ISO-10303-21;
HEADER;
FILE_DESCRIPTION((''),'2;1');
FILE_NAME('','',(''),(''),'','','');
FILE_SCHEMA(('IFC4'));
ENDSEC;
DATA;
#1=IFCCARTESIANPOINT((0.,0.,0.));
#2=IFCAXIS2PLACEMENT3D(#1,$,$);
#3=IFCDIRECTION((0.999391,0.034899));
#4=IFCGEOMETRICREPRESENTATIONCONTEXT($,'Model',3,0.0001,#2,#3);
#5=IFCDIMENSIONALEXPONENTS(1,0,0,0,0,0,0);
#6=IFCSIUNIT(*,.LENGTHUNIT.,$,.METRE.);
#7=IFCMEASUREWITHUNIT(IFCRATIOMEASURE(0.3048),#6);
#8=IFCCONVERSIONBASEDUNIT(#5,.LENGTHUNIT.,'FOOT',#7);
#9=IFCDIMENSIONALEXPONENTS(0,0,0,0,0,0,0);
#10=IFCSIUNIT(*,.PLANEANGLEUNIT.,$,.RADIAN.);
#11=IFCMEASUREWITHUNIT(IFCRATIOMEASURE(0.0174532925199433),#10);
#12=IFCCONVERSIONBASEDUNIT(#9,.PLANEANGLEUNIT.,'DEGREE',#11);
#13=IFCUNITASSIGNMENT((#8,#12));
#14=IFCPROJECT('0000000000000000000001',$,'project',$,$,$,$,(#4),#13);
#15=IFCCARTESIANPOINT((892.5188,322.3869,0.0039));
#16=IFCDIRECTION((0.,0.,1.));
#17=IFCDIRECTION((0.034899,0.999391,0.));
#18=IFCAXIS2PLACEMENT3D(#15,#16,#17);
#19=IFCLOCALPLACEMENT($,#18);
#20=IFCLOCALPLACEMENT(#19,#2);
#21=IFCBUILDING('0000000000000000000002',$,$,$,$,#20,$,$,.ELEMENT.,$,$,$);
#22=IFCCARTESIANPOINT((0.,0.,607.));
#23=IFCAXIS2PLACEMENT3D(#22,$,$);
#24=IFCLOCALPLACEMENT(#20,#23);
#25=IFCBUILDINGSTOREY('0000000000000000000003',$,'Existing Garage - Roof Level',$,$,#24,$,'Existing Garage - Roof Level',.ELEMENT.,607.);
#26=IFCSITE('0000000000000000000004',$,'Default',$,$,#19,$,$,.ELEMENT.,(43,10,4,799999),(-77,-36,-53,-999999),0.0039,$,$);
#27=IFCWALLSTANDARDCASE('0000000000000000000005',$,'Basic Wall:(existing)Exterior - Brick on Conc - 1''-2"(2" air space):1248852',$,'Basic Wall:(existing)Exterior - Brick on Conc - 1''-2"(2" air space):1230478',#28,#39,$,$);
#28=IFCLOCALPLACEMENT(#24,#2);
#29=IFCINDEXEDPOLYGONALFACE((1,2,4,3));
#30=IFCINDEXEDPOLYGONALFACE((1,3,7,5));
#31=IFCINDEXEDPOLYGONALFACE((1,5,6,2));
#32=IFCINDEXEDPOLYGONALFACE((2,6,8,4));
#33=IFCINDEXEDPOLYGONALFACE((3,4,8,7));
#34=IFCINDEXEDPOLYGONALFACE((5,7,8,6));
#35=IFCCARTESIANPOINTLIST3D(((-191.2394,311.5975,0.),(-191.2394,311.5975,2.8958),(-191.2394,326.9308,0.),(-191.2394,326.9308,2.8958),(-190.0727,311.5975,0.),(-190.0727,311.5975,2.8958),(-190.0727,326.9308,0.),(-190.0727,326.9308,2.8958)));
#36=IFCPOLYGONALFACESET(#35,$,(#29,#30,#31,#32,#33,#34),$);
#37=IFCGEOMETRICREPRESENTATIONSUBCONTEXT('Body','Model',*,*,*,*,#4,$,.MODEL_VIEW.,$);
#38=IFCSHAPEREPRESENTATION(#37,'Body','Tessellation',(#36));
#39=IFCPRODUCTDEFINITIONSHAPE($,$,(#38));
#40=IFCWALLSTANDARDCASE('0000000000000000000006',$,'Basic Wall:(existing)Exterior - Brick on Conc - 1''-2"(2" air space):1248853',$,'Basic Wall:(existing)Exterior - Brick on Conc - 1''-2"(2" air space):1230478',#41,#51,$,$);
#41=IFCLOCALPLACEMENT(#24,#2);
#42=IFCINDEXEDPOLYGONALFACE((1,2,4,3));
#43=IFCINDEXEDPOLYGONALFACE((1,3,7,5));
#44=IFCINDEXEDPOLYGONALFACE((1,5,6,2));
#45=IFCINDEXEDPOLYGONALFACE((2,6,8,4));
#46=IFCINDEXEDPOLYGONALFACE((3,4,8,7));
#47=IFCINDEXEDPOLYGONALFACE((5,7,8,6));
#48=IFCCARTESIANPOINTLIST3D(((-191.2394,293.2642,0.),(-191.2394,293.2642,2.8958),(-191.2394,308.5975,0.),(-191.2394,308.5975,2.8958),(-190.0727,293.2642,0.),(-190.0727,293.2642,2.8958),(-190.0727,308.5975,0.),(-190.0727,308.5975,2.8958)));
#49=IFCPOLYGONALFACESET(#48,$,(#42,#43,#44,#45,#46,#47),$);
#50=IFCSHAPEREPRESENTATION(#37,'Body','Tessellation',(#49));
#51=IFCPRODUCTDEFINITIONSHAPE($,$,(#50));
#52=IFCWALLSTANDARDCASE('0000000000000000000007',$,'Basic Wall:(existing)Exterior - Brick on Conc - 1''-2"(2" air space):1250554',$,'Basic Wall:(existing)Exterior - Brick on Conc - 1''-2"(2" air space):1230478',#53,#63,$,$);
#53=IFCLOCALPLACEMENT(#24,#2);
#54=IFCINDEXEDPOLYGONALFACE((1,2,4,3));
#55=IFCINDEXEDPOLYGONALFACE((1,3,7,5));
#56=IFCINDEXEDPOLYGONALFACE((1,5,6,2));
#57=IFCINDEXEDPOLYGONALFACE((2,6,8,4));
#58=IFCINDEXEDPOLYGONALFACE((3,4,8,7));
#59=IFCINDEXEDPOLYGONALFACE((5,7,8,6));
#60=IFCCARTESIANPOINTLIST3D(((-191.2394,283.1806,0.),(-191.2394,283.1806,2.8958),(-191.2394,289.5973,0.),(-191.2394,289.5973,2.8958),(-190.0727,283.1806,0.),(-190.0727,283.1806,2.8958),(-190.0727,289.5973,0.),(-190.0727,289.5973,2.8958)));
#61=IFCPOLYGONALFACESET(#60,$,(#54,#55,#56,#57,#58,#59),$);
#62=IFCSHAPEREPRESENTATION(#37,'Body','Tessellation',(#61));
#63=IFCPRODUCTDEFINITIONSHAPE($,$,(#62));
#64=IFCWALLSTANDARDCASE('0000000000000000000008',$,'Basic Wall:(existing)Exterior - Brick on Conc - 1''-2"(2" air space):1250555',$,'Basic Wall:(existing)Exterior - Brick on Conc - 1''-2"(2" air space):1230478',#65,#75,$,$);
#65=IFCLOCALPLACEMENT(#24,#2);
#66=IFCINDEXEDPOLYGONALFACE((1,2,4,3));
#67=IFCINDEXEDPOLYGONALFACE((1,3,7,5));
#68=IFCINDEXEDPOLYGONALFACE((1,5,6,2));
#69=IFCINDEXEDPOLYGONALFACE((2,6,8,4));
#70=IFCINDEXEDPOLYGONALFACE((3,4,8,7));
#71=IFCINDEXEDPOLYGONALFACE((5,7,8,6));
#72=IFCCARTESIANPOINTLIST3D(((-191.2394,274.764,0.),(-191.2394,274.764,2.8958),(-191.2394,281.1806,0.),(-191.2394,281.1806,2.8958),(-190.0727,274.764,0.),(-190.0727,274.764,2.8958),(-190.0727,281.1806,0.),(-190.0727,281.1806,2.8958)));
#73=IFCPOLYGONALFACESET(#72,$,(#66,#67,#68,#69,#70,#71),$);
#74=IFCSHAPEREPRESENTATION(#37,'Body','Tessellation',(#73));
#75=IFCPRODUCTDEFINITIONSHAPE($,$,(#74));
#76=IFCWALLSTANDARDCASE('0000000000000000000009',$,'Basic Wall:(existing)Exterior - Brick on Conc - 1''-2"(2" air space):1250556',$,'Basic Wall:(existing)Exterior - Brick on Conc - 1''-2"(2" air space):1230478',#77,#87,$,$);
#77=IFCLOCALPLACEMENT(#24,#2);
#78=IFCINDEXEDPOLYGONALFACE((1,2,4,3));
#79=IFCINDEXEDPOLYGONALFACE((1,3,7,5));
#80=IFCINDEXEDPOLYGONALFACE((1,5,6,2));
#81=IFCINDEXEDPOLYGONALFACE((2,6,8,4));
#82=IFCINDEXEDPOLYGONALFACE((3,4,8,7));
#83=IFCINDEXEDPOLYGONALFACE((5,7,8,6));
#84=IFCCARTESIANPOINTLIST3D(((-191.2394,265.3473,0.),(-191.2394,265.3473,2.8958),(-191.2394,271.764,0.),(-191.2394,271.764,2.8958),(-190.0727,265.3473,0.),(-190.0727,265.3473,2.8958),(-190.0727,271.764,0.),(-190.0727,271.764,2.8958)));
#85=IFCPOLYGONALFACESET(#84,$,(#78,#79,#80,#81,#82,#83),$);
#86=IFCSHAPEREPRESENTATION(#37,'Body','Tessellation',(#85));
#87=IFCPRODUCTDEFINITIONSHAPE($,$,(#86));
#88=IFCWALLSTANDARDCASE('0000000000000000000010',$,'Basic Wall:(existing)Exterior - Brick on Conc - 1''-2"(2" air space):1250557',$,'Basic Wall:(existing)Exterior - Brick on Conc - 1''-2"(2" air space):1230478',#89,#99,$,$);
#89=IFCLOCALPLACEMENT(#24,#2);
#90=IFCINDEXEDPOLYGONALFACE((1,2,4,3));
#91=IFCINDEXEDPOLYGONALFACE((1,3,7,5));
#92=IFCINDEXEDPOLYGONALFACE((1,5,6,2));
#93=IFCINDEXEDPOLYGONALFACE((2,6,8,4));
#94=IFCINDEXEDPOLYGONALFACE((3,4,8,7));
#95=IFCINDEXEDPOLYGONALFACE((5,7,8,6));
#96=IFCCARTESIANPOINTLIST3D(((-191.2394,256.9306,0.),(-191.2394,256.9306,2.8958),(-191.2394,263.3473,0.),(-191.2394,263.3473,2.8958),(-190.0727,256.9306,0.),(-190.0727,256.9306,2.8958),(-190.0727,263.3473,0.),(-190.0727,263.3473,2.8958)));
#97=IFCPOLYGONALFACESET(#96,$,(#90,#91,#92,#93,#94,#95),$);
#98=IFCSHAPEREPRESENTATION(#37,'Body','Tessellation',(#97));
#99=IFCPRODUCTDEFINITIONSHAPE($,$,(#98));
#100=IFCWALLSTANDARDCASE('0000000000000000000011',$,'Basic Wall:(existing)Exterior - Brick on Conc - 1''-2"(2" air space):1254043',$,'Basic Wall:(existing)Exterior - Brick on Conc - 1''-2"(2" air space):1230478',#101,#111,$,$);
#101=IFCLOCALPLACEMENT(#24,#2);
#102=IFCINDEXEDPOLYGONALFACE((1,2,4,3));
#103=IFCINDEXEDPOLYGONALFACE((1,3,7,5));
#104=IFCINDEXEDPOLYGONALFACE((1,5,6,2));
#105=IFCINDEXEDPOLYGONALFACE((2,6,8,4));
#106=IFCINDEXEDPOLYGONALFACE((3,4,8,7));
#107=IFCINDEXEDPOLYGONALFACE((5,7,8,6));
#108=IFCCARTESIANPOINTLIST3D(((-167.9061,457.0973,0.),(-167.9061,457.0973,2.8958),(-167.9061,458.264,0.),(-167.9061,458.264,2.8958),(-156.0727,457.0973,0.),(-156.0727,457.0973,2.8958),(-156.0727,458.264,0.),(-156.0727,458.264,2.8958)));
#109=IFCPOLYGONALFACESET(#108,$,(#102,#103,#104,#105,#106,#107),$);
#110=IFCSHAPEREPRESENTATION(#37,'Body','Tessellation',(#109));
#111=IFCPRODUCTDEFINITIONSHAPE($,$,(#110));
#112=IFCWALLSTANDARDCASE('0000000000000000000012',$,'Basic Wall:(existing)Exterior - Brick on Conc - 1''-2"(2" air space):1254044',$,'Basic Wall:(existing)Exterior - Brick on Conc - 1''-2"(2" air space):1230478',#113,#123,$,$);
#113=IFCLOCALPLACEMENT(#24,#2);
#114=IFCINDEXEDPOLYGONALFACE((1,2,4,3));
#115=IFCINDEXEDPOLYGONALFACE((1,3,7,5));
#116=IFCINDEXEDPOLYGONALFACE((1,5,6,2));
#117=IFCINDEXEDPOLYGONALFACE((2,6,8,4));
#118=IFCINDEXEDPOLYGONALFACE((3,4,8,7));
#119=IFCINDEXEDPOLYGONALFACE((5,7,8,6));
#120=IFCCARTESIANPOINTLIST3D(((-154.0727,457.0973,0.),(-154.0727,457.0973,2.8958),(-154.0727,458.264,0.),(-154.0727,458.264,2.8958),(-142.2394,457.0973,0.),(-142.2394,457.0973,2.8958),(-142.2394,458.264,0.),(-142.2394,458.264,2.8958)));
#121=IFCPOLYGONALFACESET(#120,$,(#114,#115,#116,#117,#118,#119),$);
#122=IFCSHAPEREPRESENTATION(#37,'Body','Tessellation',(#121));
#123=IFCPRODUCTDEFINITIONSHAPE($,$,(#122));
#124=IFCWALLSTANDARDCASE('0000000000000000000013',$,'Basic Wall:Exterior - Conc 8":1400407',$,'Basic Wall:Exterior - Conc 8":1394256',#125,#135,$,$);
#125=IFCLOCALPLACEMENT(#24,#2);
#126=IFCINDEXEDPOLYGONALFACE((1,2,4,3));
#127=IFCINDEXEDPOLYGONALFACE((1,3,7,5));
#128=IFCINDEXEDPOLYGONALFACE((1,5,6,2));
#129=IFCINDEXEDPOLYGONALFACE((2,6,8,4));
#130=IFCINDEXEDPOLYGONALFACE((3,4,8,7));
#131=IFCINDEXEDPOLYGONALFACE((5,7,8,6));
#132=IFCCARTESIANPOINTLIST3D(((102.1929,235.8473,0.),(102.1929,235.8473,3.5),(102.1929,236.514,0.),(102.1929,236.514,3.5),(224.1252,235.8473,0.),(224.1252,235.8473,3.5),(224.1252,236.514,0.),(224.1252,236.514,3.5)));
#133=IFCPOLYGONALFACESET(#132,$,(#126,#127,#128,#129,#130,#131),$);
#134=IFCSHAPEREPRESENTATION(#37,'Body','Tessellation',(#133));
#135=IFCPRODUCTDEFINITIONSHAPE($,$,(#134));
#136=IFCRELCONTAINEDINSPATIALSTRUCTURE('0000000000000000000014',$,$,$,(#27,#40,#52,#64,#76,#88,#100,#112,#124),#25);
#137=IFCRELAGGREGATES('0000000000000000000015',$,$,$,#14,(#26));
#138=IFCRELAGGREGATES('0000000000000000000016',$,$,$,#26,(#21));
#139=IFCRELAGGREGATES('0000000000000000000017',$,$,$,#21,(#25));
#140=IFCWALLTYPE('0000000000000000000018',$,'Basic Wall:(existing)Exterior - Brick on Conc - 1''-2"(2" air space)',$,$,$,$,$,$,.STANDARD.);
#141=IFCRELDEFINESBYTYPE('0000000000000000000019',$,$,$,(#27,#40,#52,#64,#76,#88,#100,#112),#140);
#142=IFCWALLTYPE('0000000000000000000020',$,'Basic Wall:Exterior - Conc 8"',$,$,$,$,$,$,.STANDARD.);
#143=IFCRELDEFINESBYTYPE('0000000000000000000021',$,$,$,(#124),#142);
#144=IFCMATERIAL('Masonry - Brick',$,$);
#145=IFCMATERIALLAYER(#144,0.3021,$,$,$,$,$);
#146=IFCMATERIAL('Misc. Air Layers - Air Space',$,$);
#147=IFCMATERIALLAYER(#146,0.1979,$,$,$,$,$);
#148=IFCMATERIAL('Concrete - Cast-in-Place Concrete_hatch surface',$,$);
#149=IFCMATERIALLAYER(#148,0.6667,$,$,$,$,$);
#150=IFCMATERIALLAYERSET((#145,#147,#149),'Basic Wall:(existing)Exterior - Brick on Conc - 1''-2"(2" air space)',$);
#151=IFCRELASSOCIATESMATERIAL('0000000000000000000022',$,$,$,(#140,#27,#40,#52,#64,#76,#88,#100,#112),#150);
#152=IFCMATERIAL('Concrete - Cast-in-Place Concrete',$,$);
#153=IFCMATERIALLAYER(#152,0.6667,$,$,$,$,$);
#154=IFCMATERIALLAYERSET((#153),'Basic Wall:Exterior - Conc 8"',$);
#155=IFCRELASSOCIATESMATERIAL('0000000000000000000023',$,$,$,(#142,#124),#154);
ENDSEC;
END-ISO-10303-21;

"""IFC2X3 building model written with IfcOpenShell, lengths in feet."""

from ifc_helpers import new_model, entity, si_unit, converted_unit, direction, frame, frame_2d, origin, place, context, subcontext, project, spatial, rectangle, extrude, material, layer, layer_set, layer_usage, type_object, element, save


model = new_model("IFC2X3")

# Units and contexts
model_context = context("Model", 3, precision=0.0001, world=origin(), true_north=direction((0.999391, 0.034899)))
body_context = subcontext(model_context, "Body", "Model", "MODEL_VIEW")
ifc_project = project(units=[converted_unit("LENGTHUNIT", "FOOT", entity("IfcRatioMeasure", 0.3048), si_unit("LENGTHUNIT", "METRE"), dimensions=[1, 0, 0, 0, 0, 0, 0]), converted_unit("PLANEANGLEUNIT", "DEGREE", entity("IfcRatioMeasure", 0.0174532925199433), si_unit("PLANEANGLEUNIT", "RADIAN"), dimensions=[0, 0, 0, 0, 0, 0, 0])], contexts=[model_context])

# Site, building, storey
site_placement = place(None, frame((892.5188, 322.3869, 0.0039), z_axis=(0.0, 0.0, 1.0), x_axis=(0.034899, 0.999391, 0.0)))
site = spatial("IfcSite", under=ifc_project, at=site_placement, Name="Default", CompositionType="ELEMENT", RefLatitude=(43, 10, 4, 799999), RefLongitude=(-77, -36, -53, -999999), RefElevation=0.0039)
building_placement = place(site_placement, origin())
building = spatial("IfcBuilding", under=site, at=building_placement, CompositionType="ELEMENT")
storey_placement = place(building_placement, frame((0.0, 0.0, 607.0)))
storey = spatial("IfcBuildingStorey", under=building, at=storey_placement, Name="Existing Garage - Roof Level", LongName="Existing Garage - Roof Level", CompositionType="ELEMENT", Elevation=607.0)

# Shared definitions
ifc_material_1 = material(Name="Concrete - Cast-in-Place Concrete")

# Walls
ifc_material_2 = material(Name="Masonry - Brick")
ifc_layer_1 = layer(ifc_material_2, 0.3021)
ifc_material_3 = material(Name="Misc. Air Layers - Air Space")
ifc_layer_2 = layer(ifc_material_3, 0.1979)
ifc_material_4 = material(Name="Concrete - Cast-in-Place Concrete_hatch surface")
ifc_layer_3 = layer(ifc_material_4, 0.6667)
ifc_layer_set_1 = layer_set([ifc_layer_1, ifc_layer_2, ifc_layer_3], Name="Basic Wall:(existing)Exterior - Brick on Conc - 1'-2\"(2\" air space)")
wall_type_1 = type_object("IfcWallType", Name="Basic Wall:(existing)Exterior - Brick on Conc - 1'-2\"(2\" air space)", PredefinedType="STANDARD", material=ifc_layer_set_1)
ifc_layer_usage_1 = layer_usage(ifc_layer_set_1, "AXIS2", "POSITIVE", -0.5833)
wall_1_placement = place(storey_placement, frame((-190.6561, 326.9308, 0.0), z_axis=(0.0, 0.0, 1.0), x_axis=(0.0, -1.0, 0.0)))
element("IfcWallStandardCase", 1, at=wall_1_placement, inside=storey, type_object=wall_type_1, material=ifc_layer_usage_1, Name="Basic Wall:(existing)Exterior - Brick on Conc - 1'-2\"(2\" air space):1248852", ObjectType="Basic Wall:(existing)Exterior - Brick on Conc - 1'-2\"(2\" air space):1230478", context=body_context, shape_type="SweptSolid", body=[
    extrude(rectangle(XDim=15.3333, YDim=1.1667, at=frame_2d((7.6667, 0.0), x_axis=(-1.0, 0.0))), origin(), (0.0, 0.0, 1.0), 2.8958),
])
ifc_layer_usage_2 = layer_usage(ifc_layer_set_1, "AXIS2", "POSITIVE", -0.5833)
wall_2_placement = place(storey_placement, frame((-190.6561, 308.5975, 0.0), z_axis=(0.0, 0.0, 1.0), x_axis=(0.0, -1.0, 0.0)))
element("IfcWallStandardCase", 2, at=wall_2_placement, inside=storey, type_object=wall_type_1, material=ifc_layer_usage_2, Name="Basic Wall:(existing)Exterior - Brick on Conc - 1'-2\"(2\" air space):1248853", ObjectType="Basic Wall:(existing)Exterior - Brick on Conc - 1'-2\"(2\" air space):1230478", context=body_context, shape_type="SweptSolid", body=[
    extrude(rectangle(XDim=15.3333, YDim=1.1667, at=frame_2d((7.6667, 0.0), x_axis=(-1.0, 0.0))), origin(), (0.0, 0.0, 1.0), 2.8958),
])
ifc_layer_usage_3 = layer_usage(ifc_layer_set_1, "AXIS2", "POSITIVE", -0.5833)
wall_3_placement = place(storey_placement, frame((-190.6561, 289.5973, 0.0), z_axis=(0.0, 0.0, 1.0), x_axis=(0.0, -1.0, 0.0)))
element("IfcWallStandardCase", 3, at=wall_3_placement, inside=storey, type_object=wall_type_1, material=ifc_layer_usage_3, Name="Basic Wall:(existing)Exterior - Brick on Conc - 1'-2\"(2\" air space):1250554", ObjectType="Basic Wall:(existing)Exterior - Brick on Conc - 1'-2\"(2\" air space):1230478", context=body_context, shape_type="SweptSolid", body=[
    extrude(rectangle(XDim=6.4167, YDim=1.1667, at=frame_2d((3.2083, 0.0), x_axis=(-1.0, 0.0))), origin(), (0.0, 0.0, 1.0), 2.8958),
])
ifc_layer_usage_4 = layer_usage(ifc_layer_set_1, "AXIS2", "POSITIVE", -0.5833)
wall_4_placement = place(storey_placement, frame((-190.6561, 281.1806, 0.0), z_axis=(0.0, 0.0, 1.0), x_axis=(0.0, -1.0, 0.0)))
element("IfcWallStandardCase", 4, at=wall_4_placement, inside=storey, type_object=wall_type_1, material=ifc_layer_usage_4, Name="Basic Wall:(existing)Exterior - Brick on Conc - 1'-2\"(2\" air space):1250555", ObjectType="Basic Wall:(existing)Exterior - Brick on Conc - 1'-2\"(2\" air space):1230478", context=body_context, shape_type="SweptSolid", body=[
    extrude(rectangle(XDim=6.4167, YDim=1.1667, at=frame_2d((3.2083, 0.0), x_axis=(-1.0, 0.0))), origin(), (0.0, 0.0, 1.0), 2.8958),
])
ifc_layer_usage_5 = layer_usage(ifc_layer_set_1, "AXIS2", "POSITIVE", -0.5833)
wall_5_placement = place(storey_placement, frame((-190.6561, 271.764, 0.0), z_axis=(0.0, 0.0, 1.0), x_axis=(0.0, -1.0, 0.0)))
element("IfcWallStandardCase", 5, at=wall_5_placement, inside=storey, type_object=wall_type_1, material=ifc_layer_usage_5, Name="Basic Wall:(existing)Exterior - Brick on Conc - 1'-2\"(2\" air space):1250556", ObjectType="Basic Wall:(existing)Exterior - Brick on Conc - 1'-2\"(2\" air space):1230478", context=body_context, shape_type="SweptSolid", body=[
    extrude(rectangle(XDim=6.4167, YDim=1.1667, at=frame_2d((3.2083, 0.0), x_axis=(-1.0, 0.0))), origin(), (0.0, 0.0, 1.0), 2.8958),
])
ifc_layer_usage_6 = layer_usage(ifc_layer_set_1, "AXIS2", "POSITIVE", -0.5833)
wall_6_placement = place(storey_placement, frame((-190.6561, 263.3473, 0.0), z_axis=(0.0, 0.0, 1.0), x_axis=(0.0, -1.0, 0.0)))
element("IfcWallStandardCase", 6, at=wall_6_placement, inside=storey, type_object=wall_type_1, material=ifc_layer_usage_6, Name="Basic Wall:(existing)Exterior - Brick on Conc - 1'-2\"(2\" air space):1250557", ObjectType="Basic Wall:(existing)Exterior - Brick on Conc - 1'-2\"(2\" air space):1230478", context=body_context, shape_type="SweptSolid", body=[
    extrude(rectangle(XDim=6.4167, YDim=1.1667, at=frame_2d((3.2083, 0.0), x_axis=(-1.0, 0.0))), origin(), (0.0, 0.0, 1.0), 2.8958),
])
ifc_layer_usage_7 = layer_usage(ifc_layer_set_1, "AXIS2", "POSITIVE", -0.5833)
wall_7_placement = place(storey_placement, frame((-156.0727, 457.6806, 0.0), z_axis=(0.0, 0.0, 1.0), x_axis=(-1.0, 0.0, 0.0)))
element("IfcWallStandardCase", 7, at=wall_7_placement, inside=storey, type_object=wall_type_1, material=ifc_layer_usage_7, Name="Basic Wall:(existing)Exterior - Brick on Conc - 1'-2\"(2\" air space):1254043", ObjectType="Basic Wall:(existing)Exterior - Brick on Conc - 1'-2\"(2\" air space):1230478", context=body_context, shape_type="SweptSolid", body=[
    extrude(rectangle(XDim=11.8333, YDim=1.1667, at=frame_2d((5.9167, 0.0), x_axis=(-1.0, 0.0))), origin(), (0.0, 0.0, 1.0), 2.8958),
])
ifc_layer_usage_8 = layer_usage(ifc_layer_set_1, "AXIS2", "NEGATIVE", 0.5833)
wall_8_placement = place(storey_placement, frame((-154.0727, 457.6806, 0.0)))
element("IfcWallStandardCase", 8, at=wall_8_placement, inside=storey, type_object=wall_type_1, material=ifc_layer_usage_8, Name="Basic Wall:(existing)Exterior - Brick on Conc - 1'-2\"(2\" air space):1254044", ObjectType="Basic Wall:(existing)Exterior - Brick on Conc - 1'-2\"(2\" air space):1230478", context=body_context, shape_type="SweptSolid", body=[
    extrude(rectangle(XDim=11.8333, YDim=1.1667, at=frame_2d((5.9167, 0.0), x_axis=(-1.0, 0.0))), origin(), (0.0, 0.0, 1.0), 2.8958),
])
ifc_layer_4 = layer(ifc_material_1, 0.6667)
ifc_layer_set_2 = layer_set([ifc_layer_4], Name="Basic Wall:Exterior - Conc 8\"")
ifc_layer_usage_9 = layer_usage(ifc_layer_set_2, "AXIS2", "NEGATIVE", 0.3333)
wall_type_2 = type_object("IfcWallType", Name="Basic Wall:Exterior - Conc 8\"", PredefinedType="STANDARD", material=ifc_layer_set_2)
wall_9_placement = place(storey_placement, frame((224.1252, 236.1806, 0.0), z_axis=(0.0, 0.0, 1.0), x_axis=(-1.0, 0.0, 0.0)))
element("IfcWallStandardCase", 9, at=wall_9_placement, inside=storey, type_object=wall_type_2, material=ifc_layer_usage_9, Name="Basic Wall:Exterior - Conc 8\":1400407", ObjectType="Basic Wall:Exterior - Conc 8\":1394256", context=body_context, shape_type="SweptSolid", body=[
    extrude(rectangle(XDim=121.9323, YDim=0.6667, at=frame_2d((60.9661, 0.0), x_axis=(-1.0, 0.0))), origin(), (0.0, 0.0, 1.0), 3.5),
])

save(model, "model.ifc")
